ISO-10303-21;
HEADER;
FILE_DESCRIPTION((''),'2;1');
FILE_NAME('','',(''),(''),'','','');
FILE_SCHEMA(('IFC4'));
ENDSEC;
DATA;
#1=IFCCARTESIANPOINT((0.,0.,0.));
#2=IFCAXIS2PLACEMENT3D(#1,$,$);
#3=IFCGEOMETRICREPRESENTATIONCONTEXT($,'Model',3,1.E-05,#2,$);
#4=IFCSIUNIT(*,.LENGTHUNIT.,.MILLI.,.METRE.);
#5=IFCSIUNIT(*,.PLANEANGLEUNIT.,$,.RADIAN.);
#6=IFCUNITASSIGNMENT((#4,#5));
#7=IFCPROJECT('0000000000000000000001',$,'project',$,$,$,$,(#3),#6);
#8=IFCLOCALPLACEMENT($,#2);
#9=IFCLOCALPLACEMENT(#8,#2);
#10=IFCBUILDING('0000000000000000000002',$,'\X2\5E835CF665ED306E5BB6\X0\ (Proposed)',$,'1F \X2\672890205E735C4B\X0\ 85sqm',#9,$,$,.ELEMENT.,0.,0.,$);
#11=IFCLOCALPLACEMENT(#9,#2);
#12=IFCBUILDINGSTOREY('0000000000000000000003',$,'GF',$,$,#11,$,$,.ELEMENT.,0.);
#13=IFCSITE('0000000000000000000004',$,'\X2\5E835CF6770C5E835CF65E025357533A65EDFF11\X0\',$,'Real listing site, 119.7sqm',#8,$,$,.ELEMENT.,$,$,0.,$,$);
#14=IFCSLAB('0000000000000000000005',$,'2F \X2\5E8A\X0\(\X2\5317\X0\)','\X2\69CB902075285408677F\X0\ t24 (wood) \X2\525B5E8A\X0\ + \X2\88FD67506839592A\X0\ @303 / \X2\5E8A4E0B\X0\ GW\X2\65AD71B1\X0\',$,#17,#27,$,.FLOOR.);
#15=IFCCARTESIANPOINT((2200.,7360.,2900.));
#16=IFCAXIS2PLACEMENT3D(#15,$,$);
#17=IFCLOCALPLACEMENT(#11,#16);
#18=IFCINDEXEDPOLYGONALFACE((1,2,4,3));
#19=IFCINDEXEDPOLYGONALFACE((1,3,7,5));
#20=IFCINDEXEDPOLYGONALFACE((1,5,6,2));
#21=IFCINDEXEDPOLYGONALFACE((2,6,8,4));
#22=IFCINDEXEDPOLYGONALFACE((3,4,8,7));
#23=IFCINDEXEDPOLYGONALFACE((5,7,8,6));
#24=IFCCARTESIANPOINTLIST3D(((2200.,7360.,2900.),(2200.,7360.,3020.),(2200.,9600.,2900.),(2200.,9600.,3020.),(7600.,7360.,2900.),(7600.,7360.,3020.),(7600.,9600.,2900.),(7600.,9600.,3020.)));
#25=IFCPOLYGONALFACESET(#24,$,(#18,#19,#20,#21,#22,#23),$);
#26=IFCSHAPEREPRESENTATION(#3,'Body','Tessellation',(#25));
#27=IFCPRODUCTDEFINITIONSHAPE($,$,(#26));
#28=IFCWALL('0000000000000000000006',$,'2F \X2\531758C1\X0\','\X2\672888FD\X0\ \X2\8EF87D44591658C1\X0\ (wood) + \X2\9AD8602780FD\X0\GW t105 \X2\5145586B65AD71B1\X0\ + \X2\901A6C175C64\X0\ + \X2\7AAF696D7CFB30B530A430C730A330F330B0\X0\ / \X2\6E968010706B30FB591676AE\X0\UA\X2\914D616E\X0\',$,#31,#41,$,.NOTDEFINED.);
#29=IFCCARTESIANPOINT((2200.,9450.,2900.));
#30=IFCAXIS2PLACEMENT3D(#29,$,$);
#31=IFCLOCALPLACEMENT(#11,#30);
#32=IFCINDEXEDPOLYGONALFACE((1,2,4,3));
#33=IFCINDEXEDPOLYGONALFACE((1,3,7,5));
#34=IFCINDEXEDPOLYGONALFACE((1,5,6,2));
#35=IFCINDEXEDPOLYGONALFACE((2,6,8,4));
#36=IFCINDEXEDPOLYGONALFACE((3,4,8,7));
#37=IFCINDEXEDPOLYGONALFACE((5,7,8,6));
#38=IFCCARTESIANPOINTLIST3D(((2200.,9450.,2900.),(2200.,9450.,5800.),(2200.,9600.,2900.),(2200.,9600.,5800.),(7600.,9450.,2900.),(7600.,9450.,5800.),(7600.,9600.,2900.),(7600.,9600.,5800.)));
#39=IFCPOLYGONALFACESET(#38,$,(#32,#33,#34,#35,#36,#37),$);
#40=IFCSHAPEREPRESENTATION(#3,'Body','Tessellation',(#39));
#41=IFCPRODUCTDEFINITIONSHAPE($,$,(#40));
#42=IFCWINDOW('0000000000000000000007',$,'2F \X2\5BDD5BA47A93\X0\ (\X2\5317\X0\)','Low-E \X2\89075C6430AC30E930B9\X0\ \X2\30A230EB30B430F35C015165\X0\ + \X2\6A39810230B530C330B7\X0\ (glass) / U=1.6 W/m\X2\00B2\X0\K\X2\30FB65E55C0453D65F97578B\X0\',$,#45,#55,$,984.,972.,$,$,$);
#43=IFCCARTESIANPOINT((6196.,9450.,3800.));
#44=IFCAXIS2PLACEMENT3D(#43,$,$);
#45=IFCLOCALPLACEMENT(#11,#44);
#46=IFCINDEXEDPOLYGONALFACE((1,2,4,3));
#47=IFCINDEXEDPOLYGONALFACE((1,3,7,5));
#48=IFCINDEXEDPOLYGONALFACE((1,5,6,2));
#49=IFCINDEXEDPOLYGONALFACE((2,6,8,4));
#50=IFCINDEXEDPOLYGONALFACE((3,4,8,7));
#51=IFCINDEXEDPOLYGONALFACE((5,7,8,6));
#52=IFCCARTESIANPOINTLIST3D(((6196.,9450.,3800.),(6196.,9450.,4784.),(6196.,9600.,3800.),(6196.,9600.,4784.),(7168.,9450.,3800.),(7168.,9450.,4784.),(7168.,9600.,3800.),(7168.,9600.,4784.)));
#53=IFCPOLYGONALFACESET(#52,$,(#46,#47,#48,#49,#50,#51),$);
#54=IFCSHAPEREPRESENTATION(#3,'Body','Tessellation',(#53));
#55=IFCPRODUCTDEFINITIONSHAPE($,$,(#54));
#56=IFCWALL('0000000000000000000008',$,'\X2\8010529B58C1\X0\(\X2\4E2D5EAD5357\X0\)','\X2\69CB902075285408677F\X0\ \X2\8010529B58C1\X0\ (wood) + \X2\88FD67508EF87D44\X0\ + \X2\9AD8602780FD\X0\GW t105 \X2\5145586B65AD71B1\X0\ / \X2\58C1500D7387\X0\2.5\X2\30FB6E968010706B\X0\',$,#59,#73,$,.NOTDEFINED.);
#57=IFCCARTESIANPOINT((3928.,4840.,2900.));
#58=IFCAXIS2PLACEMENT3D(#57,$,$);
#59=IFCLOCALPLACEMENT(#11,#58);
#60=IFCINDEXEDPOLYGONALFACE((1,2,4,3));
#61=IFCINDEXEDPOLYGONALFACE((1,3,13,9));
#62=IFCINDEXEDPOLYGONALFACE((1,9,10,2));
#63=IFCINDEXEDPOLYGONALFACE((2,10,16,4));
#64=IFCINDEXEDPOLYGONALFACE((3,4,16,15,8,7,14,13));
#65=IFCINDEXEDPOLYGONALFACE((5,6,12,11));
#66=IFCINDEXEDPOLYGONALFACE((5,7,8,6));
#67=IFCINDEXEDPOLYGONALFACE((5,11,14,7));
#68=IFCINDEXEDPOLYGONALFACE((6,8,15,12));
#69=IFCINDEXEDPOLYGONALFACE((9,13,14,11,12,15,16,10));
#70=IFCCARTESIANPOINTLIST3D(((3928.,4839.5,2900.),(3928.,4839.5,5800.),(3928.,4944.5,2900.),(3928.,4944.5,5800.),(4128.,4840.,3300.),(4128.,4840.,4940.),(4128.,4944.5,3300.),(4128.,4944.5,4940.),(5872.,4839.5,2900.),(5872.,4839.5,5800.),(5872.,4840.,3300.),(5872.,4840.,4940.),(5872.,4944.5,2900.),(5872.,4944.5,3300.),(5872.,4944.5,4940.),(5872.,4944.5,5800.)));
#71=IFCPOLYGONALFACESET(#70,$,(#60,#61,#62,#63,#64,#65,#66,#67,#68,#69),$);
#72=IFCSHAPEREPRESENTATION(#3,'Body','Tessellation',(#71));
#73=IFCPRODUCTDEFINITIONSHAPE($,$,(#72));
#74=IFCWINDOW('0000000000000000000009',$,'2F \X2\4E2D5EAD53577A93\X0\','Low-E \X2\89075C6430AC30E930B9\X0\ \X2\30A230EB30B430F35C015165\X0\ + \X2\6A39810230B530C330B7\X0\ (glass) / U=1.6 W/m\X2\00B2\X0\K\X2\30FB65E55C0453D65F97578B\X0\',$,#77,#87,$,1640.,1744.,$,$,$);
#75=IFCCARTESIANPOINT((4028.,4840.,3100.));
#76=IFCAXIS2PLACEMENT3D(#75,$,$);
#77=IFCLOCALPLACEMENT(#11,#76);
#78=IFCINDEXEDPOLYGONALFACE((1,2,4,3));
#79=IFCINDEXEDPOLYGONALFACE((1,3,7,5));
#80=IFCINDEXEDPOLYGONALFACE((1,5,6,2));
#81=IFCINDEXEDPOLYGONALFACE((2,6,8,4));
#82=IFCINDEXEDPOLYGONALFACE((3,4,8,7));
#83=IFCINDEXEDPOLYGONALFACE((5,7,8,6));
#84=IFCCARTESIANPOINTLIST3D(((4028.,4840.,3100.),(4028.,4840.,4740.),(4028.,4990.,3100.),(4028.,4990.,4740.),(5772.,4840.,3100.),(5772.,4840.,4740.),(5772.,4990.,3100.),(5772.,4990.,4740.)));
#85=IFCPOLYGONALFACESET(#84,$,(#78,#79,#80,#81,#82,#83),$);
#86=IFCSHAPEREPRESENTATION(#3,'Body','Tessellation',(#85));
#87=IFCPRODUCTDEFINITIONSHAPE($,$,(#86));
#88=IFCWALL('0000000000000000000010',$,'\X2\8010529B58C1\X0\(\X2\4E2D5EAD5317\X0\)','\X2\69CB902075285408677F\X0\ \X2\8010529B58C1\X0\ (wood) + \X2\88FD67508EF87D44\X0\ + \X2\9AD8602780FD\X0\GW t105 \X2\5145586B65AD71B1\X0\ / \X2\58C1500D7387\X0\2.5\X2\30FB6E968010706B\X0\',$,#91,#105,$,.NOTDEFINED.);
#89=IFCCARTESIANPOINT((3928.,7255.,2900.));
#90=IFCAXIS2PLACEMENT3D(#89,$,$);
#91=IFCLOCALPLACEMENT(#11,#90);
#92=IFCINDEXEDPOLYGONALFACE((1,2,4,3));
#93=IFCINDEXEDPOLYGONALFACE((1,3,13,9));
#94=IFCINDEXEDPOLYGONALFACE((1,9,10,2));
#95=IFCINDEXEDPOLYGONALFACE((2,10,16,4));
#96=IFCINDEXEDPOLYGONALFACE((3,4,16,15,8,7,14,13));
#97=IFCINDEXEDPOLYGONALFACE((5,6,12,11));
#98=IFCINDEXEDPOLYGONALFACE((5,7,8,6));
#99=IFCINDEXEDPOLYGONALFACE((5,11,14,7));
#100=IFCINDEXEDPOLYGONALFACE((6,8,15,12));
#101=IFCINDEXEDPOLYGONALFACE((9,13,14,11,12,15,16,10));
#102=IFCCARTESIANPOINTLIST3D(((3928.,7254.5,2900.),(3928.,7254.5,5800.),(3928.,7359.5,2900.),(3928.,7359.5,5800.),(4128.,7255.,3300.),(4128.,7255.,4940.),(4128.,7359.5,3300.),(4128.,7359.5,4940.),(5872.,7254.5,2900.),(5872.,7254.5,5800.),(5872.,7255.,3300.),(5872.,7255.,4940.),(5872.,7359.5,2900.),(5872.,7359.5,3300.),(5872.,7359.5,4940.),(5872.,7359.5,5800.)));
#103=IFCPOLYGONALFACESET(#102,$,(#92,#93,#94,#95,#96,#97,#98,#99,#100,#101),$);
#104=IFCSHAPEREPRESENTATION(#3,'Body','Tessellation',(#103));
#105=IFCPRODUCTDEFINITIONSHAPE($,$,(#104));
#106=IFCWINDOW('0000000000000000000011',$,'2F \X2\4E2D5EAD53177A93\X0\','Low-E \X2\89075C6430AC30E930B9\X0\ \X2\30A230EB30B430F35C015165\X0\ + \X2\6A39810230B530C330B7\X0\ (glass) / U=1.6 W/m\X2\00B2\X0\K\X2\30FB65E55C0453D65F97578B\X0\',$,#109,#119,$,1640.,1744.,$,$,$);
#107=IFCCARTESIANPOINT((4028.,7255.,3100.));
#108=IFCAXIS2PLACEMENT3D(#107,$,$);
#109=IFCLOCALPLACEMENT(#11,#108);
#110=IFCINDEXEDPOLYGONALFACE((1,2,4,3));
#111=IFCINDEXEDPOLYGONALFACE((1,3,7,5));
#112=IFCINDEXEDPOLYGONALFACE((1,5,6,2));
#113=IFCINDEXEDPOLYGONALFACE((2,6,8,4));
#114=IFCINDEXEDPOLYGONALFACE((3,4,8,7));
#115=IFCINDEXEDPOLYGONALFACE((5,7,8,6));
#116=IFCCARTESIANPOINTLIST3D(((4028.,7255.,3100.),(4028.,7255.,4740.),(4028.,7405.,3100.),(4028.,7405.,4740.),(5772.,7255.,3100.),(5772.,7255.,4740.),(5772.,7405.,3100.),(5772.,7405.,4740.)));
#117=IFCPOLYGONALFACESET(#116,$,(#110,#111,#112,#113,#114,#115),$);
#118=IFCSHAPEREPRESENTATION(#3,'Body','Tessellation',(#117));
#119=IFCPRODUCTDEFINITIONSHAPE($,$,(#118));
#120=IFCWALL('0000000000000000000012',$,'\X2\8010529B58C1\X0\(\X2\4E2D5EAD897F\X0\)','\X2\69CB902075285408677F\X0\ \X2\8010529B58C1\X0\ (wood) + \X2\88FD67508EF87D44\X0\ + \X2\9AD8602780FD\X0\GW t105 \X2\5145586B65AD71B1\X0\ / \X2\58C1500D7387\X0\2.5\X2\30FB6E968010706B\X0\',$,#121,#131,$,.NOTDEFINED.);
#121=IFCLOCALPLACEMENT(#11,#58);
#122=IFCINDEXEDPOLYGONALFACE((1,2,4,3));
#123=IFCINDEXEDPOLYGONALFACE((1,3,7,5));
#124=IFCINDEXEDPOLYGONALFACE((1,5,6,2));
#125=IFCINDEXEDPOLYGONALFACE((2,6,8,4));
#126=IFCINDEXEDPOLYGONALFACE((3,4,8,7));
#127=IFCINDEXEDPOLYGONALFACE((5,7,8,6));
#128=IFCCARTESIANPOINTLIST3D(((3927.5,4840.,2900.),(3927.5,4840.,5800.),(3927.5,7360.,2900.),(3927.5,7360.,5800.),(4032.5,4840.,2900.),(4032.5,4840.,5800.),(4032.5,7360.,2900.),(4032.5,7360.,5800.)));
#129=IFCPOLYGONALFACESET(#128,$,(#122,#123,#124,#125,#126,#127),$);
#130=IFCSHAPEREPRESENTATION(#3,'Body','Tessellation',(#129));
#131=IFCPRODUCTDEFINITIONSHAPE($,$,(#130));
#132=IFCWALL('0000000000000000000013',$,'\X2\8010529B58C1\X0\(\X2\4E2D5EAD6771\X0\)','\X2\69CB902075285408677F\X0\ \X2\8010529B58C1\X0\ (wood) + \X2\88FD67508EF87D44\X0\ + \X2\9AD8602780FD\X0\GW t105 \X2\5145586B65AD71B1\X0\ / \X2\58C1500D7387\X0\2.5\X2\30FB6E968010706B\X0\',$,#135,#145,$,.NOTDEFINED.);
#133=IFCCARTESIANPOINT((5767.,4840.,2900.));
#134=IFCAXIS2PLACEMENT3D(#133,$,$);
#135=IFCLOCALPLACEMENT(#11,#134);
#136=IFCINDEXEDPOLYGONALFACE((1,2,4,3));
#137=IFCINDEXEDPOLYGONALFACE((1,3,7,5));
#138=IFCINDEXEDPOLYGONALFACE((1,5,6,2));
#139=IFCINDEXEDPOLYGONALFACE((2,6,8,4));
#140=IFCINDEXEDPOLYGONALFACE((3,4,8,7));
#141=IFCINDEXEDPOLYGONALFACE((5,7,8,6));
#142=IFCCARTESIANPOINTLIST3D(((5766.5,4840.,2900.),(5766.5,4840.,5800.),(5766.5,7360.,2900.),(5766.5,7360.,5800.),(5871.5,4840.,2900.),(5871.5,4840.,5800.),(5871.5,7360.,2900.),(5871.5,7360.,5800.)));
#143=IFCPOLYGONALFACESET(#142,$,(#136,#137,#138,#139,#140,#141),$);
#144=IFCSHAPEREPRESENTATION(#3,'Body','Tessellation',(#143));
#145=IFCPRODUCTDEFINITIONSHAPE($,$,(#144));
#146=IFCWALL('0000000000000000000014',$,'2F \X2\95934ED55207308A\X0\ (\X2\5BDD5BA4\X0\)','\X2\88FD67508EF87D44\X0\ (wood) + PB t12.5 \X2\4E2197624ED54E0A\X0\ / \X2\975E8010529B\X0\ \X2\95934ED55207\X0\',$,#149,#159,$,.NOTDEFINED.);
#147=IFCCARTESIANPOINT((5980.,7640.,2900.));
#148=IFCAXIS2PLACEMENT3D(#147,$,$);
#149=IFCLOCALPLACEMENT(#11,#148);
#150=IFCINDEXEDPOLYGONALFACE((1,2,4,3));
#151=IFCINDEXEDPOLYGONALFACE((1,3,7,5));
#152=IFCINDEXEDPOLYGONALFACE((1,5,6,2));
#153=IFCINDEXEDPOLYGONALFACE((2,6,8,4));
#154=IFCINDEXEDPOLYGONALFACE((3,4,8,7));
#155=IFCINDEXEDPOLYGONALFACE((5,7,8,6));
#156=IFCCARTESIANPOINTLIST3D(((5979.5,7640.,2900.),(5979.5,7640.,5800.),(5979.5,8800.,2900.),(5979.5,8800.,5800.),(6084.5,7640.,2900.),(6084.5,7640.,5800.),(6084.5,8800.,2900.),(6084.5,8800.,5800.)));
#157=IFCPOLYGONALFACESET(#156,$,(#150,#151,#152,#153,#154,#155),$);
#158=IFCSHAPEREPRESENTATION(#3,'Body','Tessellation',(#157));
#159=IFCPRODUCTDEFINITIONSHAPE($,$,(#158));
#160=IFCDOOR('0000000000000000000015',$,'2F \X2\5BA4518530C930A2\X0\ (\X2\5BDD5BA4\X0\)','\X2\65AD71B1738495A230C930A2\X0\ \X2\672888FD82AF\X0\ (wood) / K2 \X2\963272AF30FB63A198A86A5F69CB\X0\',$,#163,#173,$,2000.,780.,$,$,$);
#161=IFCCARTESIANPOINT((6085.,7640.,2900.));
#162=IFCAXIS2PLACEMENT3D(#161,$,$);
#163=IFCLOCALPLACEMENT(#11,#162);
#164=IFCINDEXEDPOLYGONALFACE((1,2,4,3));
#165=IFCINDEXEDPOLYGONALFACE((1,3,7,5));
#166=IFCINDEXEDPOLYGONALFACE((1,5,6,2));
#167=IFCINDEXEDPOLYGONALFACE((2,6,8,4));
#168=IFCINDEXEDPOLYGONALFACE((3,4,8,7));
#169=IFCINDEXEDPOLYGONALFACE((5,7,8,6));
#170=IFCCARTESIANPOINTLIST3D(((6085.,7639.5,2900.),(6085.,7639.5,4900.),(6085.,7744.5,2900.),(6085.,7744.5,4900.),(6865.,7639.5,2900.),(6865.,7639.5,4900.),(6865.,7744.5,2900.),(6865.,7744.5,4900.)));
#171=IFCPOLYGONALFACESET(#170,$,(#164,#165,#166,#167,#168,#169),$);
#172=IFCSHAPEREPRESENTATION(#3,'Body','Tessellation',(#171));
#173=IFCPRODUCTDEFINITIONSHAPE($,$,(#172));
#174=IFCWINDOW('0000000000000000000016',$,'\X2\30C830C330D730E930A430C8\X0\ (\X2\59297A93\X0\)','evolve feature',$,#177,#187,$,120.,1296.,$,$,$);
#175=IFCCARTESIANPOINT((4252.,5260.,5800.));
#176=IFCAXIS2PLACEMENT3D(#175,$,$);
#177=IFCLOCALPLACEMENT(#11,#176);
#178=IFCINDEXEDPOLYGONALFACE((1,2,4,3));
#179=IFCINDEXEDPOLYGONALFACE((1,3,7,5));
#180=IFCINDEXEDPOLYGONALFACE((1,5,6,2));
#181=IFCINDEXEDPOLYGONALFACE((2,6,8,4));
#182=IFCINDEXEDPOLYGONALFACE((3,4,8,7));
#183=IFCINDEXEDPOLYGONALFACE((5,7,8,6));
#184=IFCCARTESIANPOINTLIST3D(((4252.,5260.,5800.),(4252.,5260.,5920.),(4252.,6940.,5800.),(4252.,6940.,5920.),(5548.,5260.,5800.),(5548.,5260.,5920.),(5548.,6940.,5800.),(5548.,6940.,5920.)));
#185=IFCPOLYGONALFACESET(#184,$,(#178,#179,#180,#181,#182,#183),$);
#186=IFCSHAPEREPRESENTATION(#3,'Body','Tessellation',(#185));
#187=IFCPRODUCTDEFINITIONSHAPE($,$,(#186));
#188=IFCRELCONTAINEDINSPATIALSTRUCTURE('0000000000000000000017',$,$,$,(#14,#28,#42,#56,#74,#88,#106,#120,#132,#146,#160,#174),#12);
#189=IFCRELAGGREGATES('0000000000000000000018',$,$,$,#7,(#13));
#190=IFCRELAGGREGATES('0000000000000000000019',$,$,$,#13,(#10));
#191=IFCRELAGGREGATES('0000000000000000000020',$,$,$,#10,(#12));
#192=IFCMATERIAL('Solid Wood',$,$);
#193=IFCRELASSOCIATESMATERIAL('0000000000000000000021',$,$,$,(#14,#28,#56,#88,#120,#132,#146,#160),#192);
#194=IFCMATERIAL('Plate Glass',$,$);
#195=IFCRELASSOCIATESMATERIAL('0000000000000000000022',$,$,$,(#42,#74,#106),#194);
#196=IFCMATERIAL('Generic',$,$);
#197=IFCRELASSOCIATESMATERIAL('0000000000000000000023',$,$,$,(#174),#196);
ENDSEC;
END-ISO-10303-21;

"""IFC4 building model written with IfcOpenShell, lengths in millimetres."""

from ifc_helpers import new_model, si_unit, frame, frame_2d, origin, place, context, project, spatial, rectangle, extrude, material, element, fill, save


model = new_model("IFC4")

# Units and contexts
model_context = context("Model", 3, precision=1e-05, world=origin())
ifc_project = project(units=[si_unit("LENGTHUNIT", "METRE", prefix="MILLI"), si_unit("PLANEANGLEUNIT", "RADIAN")], contexts=[model_context])

# Site, building, storey
site_placement = place(None, origin())
site = spatial("IfcSite", under=ifc_project, at=site_placement, Name="広島県広島市南区旭１", ObjectType="Real listing site, 119.7sqm", CompositionType="ELEMENT", RefElevation=0.0)
building_placement = place(site_placement, origin())
building = spatial("IfcBuilding", under=site, at=building_placement, Name="広島旭の家 (Proposed)", ObjectType="1F 木造平屋 85sqm", CompositionType="ELEMENT", ElevationOfRefHeight=0.0, ElevationOfTerrain=0.0)
storey_placement = place(building_placement, origin())
storey = spatial("IfcBuildingStorey", under=building, at=storey_placement, Name="GF", CompositionType="ELEMENT", Elevation=0.0)

# Slab
ifc_material_1 = material(Name="Solid Wood")
slab_placement = place(storey_placement, frame((2200.0, 7360.0, 2900.0)))
element("IfcSlab", 1, at=slab_placement, inside=storey, material=ifc_material_1, Name="2F 床(北)", Description="構造用合板 t24 (wood) 剛床 + 製材根太 @303 / 床下 GW断熱", PredefinedType="FLOOR", context=model_context, shape_type="SweptSolid", body=[
    extrude(rectangle(XDim=5400.0, YDim=2240.0, at=frame_2d((2700.0, 1120.0))), frame((2200.0, 7360.0, 2900.0)), (0.0, 0.0, 1.0), 120.0),
])

# Walls, openings, windows
wall_1_placement = place(storey_placement, frame((2200.0, 9450.0, 2900.0)))
wall_1 = element("IfcWall", 2, at=wall_1_placement, inside=storey, material=ifc_material_1, Name="2F 北壁", Description="木製 軸組外壁 (wood) + 高性能GW t105 充填断熱 + 通気層 + 窯業系サイディング / 準耐火・外皮UA配慮", PredefinedType="NOTDEFINED", context=model_context, shape_type="SweptSolid", body=[
    extrude(rectangle(XDim=5400.0, YDim=150.0, at=frame_2d((2700.0, 75.0))), frame((2200.0, 9450.0, 2900.0)), (0.0, 0.0, 1.0), 2900.0),
])
opening_1_placement = place(storey_placement, frame((6196.0, 9450.0, 3800.0)))
opening_1 = element("IfcOpeningElement", 3, at=opening_1_placement, cuts=wall_1, PredefinedType="NOTDEFINED", context=model_context, shape_type="SweptSolid", body=[
    extrude(rectangle(XDim=972.0, YDim=150.0, at=frame_2d((486.0, 75.0))), frame((6196.0, 9450.0, 3800.0)), (0.0, 0.0, 1.0), 984.0),
])
ifc_material_2 = material(Name="Plate Glass")
window_1_placement = place(storey_placement, frame((6196.0, 9450.0, 3800.0)))
window_1 = element("IfcWindow", 4, at=window_1_placement, inside=storey, material=ifc_material_2, Name="2F 寝室窓 (北)", Description="Low-E 複層ガラス アルゴン封入 + 樹脂サッシ (glass) / U=1.6 W/m²K・日射取得型", OverallHeight=984.0, OverallWidth=972.0, context=model_context, shape_type="SweptSolid", body=[
    extrude(rectangle(XDim=972.0, YDim=150.0, at=frame_2d((486.0, 75.0))), frame((6196.0, 9450.0, 3800.0)), (0.0, 0.0, 1.0), 984.0),
])
fill(opening_1, window_1)
wall_2_placement = place(storey_placement, frame((3928.0, 4840.0, 2900.0)))
wall_2 = element("IfcWall", 5, at=wall_2_placement, inside=storey, material=ifc_material_1, Name="耐力壁(中庭南)", Description="構造用合板 耐力壁 (wood) + 製材軸組 + 高性能GW t105 充填断熱 / 壁倍率2.5・準耐火", PredefinedType="NOTDEFINED", context=model_context, shape_type="SweptSolid", body=[
    extrude(rectangle(XDim=1944.0, YDim=105.0, at=frame_2d((972.0, 52.0))), frame((3928.0, 4840.0, 2900.0)), (0.0, 0.0, 1.0), 2900.0),
])
opening_2_placement = place(storey_placement, frame((4028.0, 4840.0, 3100.0)))
opening_2 = element("IfcOpeningElement", 6, at=opening_2_placement, cuts=wall_2, PredefinedType="NOTDEFINED", context=model_context, shape_type="SweptSolid", body=[
    extrude(rectangle(XDim=1744.0, YDim=150.0, at=frame_2d((872.0, 75.0))), frame((4028.0, 4840.0, 3100.0)), (0.0, 0.0, 1.0), 1640.0),
])
window_2_placement = place(storey_placement, frame((4028.0, 4840.0, 3100.0)))
window_2 = element("IfcWindow", 7, at=window_2_placement, inside=storey, material=ifc_material_2, Name="2F 中庭南窓", Description="Low-E 複層ガラス アルゴン封入 + 樹脂サッシ (glass) / U=1.6 W/m²K・日射取得型", OverallHeight=1640.0, OverallWidth=1744.0, context=model_context, shape_type="SweptSolid", body=[
    extrude(rectangle(XDim=1744.0, YDim=150.0, at=frame_2d((872.0, 75.0))), frame((4028.0, 4840.0, 3100.0)), (0.0, 0.0, 1.0), 1640.0),
])
fill(opening_2, window_2)
wall_3_placement = place(storey_placement, frame((3928.0, 7255.0, 2900.0)))
wall_3 = element("IfcWall", 8, at=wall_3_placement, inside=storey, material=ifc_material_1, Name="耐力壁(中庭北)", Description="構造用合板 耐力壁 (wood) + 製材軸組 + 高性能GW t105 充填断熱 / 壁倍率2.5・準耐火", PredefinedType="NOTDEFINED", context=model_context, shape_type="SweptSolid", body=[
    extrude(rectangle(XDim=1944.0, YDim=105.0, at=frame_2d((972.0, 52.0))), frame((3928.0, 7255.0, 2900.0)), (0.0, 0.0, 1.0), 2900.0),
])
opening_3_placement = place(storey_placement, frame((4028.0, 7255.0, 3100.0)))
opening_3 = element("IfcOpeningElement", 9, at=opening_3_placement, cuts=wall_3, PredefinedType="NOTDEFINED", context=model_context, shape_type="SweptSolid", body=[
    extrude(rectangle(XDim=1744.0, YDim=150.0, at=frame_2d((872.0, 75.0))), frame((4028.0, 7255.0, 3100.0)), (0.0, 0.0, 1.0), 1640.0),
])
window_3_placement = place(storey_placement, frame((4028.0, 7255.0, 3100.0)))
window_3 = element("IfcWindow", 10, at=window_3_placement, inside=storey, material=ifc_material_2, Name="2F 中庭北窓", Description="Low-E 複層ガラス アルゴン封入 + 樹脂サッシ (glass) / U=1.6 W/m²K・日射取得型", OverallHeight=1640.0, OverallWidth=1744.0, context=model_context, shape_type="SweptSolid", body=[
    extrude(rectangle(XDim=1744.0, YDim=150.0, at=frame_2d((872.0, 75.0))), frame((4028.0, 7255.0, 3100.0)), (0.0, 0.0, 1.0), 1640.0),
])
fill(opening_3, window_3)

# Walls
wall_4_placement = place(storey_placement, frame((3928.0, 4840.0, 2900.0)))
element("IfcWall", 11, at=wall_4_placement, inside=storey, material=ifc_material_1, Name="耐力壁(中庭西)", Description="構造用合板 耐力壁 (wood) + 製材軸組 + 高性能GW t105 充填断熱 / 壁倍率2.5・準耐火", PredefinedType="NOTDEFINED", context=model_context, shape_type="SweptSolid", body=[
    extrude(rectangle(XDim=105.0, YDim=2520.0, at=frame_2d((52.0, 1260.0))), frame((3928.0, 4840.0, 2900.0)), (0.0, 0.0, 1.0), 2900.0),
])
wall_5_placement = place(storey_placement, frame((5767.0, 4840.0, 2900.0)))
element("IfcWall", 12, at=wall_5_placement, inside=storey, material=ifc_material_1, Name="耐力壁(中庭東)", Description="構造用合板 耐力壁 (wood) + 製材軸組 + 高性能GW t105 充填断熱 / 壁倍率2.5・準耐火", PredefinedType="NOTDEFINED", context=model_context, shape_type="SweptSolid", body=[
    extrude(rectangle(XDim=105.0, YDim=2520.0, at=frame_2d((52.0, 1260.0))), frame((5767.0, 4840.0, 2900.0)), (0.0, 0.0, 1.0), 2900.0),
])
wall_6_placement = place(storey_placement, frame((5980.0, 7640.0, 2900.0)))
element("IfcWall", 13, at=wall_6_placement, inside=storey, material=ifc_material_1, Name="2F 間仕切り (寝室)", Description="製材軸組 (wood) + PB t12.5 両面仕上 / 非耐力 間仕切", PredefinedType="NOTDEFINED", context=model_context, shape_type="SweptSolid", body=[
    extrude(rectangle(XDim=105.0, YDim=1160.0, at=frame_2d((52.0, 580.0))), frame((5980.0, 7640.0, 2900.0)), (0.0, 0.0, 1.0), 2900.0),
])

# Door
door_placement = place(storey_placement, frame((6085.0, 7640.0, 2900.0)))
element("IfcDoor", 14, at=door_placement, inside=storey, material=ifc_material_1, Name="2F 室内ドア (寝室)", Description="断熱玄関ドア 木製芯 (wood) / K2 防犯・採風機構", OverallHeight=2000.0, OverallWidth=780.0, context=model_context, shape_type="SweptSolid", body=[
    extrude(rectangle(XDim=780.0, YDim=105.0, at=frame_2d((390.0, 52.0))), frame((6085.0, 7640.0, 2900.0)), (0.0, 0.0, 1.0), 2000.0),
])

# Window
ifc_material_3 = material(Name="Generic")
window_4_placement = place(storey_placement, frame((4252.0, 5260.0, 5800.0)))
element("IfcWindow", 15, at=window_4_placement, inside=storey, material=ifc_material_3, Name="トップライト (天窓)", Description="evolve feature", OverallHeight=120.0, OverallWidth=1296.0, context=model_context, shape_type="SweptSolid", body=[
    extrude(rectangle(XDim=1296.0, YDim=1680.0, at=frame_2d((648.0, 840.0))), frame((4252.0, 5260.0, 5800.0)), (0.0, 0.0, 1.0), 120.0),
])

save(model, "model.ifc")
